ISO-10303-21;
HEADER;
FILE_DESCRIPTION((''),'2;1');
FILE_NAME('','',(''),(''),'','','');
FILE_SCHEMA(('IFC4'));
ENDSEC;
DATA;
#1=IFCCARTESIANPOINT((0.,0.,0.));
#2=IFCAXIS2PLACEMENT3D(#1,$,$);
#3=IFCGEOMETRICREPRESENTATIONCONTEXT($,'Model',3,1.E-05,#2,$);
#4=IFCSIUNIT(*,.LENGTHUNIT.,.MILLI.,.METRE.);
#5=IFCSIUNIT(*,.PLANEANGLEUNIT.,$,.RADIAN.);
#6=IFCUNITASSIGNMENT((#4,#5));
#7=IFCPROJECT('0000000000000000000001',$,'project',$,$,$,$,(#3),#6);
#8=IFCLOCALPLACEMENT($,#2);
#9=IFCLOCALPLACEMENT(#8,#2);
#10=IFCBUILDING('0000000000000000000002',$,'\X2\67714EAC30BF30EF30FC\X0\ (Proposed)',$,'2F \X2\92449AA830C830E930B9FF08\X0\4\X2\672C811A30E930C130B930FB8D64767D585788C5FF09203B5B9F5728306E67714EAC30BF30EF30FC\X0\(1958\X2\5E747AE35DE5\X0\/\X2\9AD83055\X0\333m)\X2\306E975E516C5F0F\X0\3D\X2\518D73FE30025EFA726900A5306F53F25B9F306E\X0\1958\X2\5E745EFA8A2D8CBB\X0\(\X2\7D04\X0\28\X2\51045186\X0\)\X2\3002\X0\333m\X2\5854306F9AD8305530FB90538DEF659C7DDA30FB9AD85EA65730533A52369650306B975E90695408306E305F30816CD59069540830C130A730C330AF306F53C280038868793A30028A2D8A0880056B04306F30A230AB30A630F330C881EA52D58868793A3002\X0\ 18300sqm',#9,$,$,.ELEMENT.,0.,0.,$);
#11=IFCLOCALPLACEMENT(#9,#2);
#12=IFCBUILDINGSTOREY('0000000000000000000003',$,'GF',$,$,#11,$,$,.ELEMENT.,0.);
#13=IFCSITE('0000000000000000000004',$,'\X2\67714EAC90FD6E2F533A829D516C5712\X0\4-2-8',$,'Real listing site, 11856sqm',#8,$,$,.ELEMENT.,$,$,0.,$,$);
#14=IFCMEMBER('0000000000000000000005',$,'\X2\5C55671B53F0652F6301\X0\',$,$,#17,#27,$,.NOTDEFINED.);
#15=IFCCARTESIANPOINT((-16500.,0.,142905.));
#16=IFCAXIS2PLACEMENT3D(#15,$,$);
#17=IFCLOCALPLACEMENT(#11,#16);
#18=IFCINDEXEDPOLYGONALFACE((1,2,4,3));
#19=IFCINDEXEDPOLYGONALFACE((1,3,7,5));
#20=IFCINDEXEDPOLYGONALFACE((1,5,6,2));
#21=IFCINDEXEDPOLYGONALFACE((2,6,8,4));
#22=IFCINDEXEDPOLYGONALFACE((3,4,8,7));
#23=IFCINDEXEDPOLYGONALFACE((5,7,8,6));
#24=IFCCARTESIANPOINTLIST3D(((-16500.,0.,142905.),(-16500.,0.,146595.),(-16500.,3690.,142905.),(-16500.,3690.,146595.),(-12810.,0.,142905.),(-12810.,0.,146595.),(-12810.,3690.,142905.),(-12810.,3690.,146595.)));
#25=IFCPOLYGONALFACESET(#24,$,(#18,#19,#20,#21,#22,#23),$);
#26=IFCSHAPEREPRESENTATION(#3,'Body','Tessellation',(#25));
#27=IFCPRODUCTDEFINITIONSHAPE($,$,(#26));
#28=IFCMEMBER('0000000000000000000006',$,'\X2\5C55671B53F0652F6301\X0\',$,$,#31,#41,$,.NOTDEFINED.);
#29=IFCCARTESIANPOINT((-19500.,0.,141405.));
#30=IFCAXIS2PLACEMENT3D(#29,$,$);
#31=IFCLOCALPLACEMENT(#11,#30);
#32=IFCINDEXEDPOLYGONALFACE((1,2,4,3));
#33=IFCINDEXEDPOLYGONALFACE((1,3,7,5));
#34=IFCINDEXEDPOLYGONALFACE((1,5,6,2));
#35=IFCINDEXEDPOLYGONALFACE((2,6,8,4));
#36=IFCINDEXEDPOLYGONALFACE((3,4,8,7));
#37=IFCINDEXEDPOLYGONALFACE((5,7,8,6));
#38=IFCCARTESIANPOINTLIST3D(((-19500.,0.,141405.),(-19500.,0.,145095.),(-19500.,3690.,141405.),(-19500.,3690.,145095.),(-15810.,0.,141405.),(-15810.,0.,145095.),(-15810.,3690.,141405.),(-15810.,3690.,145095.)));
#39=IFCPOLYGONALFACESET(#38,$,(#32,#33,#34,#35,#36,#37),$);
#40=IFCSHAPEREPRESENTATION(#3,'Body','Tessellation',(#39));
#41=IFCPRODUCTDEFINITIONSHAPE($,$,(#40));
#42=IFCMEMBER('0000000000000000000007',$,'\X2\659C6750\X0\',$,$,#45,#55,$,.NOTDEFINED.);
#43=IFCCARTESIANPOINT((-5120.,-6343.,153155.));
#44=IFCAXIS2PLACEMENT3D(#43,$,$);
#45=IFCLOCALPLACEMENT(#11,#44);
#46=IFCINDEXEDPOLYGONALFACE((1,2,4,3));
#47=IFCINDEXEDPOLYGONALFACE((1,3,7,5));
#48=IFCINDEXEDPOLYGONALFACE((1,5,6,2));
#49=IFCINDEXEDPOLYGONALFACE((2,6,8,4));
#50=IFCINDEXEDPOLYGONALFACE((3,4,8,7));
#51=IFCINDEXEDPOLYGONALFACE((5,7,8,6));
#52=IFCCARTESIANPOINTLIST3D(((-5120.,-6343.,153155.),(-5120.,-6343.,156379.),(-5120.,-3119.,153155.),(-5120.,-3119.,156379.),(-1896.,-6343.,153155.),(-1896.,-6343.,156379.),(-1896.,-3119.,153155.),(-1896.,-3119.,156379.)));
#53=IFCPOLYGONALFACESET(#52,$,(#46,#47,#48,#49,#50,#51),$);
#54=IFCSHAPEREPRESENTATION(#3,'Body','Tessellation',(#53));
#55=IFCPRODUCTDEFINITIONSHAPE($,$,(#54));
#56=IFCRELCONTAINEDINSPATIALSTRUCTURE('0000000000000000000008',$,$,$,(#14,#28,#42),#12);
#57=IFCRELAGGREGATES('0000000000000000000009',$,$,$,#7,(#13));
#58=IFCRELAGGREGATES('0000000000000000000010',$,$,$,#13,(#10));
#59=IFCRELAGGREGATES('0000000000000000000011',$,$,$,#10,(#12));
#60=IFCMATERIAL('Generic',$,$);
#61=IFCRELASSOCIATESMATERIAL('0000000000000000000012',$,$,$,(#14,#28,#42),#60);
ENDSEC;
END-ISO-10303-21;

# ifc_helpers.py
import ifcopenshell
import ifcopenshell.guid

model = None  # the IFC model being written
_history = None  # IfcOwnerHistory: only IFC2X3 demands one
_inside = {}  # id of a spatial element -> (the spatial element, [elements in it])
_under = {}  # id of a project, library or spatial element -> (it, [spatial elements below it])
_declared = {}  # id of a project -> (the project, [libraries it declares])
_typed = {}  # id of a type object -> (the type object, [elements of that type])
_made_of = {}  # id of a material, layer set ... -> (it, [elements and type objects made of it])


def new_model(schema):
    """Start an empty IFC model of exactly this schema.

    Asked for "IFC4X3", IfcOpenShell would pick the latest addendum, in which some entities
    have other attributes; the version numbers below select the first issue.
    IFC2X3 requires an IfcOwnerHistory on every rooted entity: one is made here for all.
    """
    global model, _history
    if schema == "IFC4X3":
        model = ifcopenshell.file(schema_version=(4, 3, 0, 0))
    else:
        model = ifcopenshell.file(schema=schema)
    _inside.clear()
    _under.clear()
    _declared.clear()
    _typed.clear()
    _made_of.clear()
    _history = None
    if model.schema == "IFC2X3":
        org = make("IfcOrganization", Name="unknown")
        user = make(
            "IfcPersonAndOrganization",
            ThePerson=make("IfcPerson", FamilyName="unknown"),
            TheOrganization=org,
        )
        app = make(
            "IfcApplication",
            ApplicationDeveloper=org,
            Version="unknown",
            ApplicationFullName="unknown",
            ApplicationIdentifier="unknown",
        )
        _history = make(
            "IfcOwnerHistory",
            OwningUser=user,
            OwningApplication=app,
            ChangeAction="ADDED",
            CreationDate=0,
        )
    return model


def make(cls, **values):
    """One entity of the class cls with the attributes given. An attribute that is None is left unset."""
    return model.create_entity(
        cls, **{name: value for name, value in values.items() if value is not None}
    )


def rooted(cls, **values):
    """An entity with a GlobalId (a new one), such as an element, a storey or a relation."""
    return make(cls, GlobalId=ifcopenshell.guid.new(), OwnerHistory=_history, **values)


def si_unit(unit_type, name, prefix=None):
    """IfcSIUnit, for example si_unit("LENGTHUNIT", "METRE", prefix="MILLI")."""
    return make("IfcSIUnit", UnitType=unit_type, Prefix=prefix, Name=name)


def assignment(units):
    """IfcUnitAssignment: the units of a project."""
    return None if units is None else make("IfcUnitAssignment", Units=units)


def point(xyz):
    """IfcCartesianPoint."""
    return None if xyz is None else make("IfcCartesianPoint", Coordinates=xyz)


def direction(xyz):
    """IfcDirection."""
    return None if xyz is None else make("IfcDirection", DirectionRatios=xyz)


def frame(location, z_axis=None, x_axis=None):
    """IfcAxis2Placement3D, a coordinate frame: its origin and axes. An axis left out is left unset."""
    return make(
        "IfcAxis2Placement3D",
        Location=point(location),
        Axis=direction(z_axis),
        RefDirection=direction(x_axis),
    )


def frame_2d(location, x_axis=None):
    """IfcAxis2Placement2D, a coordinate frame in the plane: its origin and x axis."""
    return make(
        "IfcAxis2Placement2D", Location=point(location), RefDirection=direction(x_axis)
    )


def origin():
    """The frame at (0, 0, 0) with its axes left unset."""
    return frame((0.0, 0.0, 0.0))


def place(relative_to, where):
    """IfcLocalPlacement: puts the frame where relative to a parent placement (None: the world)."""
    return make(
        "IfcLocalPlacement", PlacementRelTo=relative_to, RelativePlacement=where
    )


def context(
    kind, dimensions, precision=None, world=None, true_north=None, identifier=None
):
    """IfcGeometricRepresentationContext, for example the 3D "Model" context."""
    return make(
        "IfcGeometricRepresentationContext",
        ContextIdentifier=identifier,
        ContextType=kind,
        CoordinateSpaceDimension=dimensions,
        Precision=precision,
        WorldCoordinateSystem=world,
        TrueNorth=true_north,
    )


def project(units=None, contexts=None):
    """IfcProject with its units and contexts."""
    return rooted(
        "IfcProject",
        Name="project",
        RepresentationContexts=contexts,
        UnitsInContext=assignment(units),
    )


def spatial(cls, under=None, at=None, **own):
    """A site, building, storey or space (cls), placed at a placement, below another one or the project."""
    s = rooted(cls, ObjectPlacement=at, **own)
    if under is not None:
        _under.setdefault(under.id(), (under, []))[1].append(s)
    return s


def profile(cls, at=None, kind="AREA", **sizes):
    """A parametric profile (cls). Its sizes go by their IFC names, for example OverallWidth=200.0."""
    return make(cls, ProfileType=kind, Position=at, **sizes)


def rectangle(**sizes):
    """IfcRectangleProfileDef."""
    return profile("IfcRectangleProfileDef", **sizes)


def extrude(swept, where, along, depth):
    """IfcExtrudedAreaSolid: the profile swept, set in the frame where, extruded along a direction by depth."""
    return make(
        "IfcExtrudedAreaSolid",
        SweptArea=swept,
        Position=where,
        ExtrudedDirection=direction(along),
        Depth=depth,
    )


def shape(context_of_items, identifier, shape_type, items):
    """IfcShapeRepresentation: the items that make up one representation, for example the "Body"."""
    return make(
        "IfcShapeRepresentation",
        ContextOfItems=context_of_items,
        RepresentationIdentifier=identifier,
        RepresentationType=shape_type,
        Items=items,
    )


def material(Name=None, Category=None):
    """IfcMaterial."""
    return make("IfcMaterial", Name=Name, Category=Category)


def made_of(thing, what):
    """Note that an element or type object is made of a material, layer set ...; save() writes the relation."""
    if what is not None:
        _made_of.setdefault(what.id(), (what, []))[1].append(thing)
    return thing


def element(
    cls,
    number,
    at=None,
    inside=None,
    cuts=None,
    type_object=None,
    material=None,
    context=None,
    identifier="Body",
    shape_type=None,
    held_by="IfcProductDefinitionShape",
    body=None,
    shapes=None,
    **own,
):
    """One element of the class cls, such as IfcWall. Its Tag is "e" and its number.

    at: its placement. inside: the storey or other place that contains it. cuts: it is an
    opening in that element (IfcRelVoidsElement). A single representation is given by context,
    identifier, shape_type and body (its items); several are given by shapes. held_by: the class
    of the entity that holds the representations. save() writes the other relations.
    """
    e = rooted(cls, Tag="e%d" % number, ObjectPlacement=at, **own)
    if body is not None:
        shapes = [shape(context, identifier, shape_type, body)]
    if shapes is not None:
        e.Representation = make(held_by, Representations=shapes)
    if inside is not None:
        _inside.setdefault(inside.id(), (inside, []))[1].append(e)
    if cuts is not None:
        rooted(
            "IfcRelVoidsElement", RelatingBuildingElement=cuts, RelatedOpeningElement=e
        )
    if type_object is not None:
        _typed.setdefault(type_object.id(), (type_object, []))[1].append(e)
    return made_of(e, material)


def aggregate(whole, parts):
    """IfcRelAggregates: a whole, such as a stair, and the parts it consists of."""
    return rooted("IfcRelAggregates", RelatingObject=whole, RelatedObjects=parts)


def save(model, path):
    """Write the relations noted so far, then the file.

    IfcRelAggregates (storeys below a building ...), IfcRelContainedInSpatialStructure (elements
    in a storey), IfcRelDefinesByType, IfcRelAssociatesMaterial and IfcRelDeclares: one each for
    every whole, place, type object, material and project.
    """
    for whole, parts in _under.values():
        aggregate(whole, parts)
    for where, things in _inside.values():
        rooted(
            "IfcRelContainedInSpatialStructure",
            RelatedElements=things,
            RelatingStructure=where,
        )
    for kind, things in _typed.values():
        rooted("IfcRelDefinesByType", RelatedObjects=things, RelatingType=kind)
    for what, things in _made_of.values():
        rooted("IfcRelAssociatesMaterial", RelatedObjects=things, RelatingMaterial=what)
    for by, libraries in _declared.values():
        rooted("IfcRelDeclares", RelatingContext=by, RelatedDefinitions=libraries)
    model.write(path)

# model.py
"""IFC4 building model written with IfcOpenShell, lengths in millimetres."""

from ifc_helpers import new_model, si_unit, frame, frame_2d, origin, place, context, project, spatial, rectangle, extrude, material, element, save


model = new_model("IFC4")

# Units and contexts
model_context = context("Model", 3, precision=1e-05, world=origin())
ifc_project = project(units=[si_unit("LENGTHUNIT", "METRE", prefix="MILLI"), si_unit("PLANEANGLEUNIT", "RADIAN")], contexts=[model_context])

# Site, building, storey
site_placement = place(None, origin())
site = spatial("IfcSite", under=ifc_project, at=site_placement, Name="東京都港区芝公園4-2-8", ObjectType="Real listing site, 11856sqm", CompositionType="ELEMENT", RefElevation=0.0)
building_placement = place(site_placement, origin())
building = spatial("IfcBuilding", under=site, at=building_placement, Name="東京タワー (Proposed)", ObjectType="2F 鉄骨トラス（4本脚ラチス・赤白塗装）※実在の東京タワー(1958年竣工/高さ333m)の非公式3D再現。建物¥は史実の1958年建設費(約28億円)。333m塔は高さ・道路斜線・高度地区制限に非適合のため法適合チェックは参考表示。設計者欄はアカウント自動表示。 18300sqm", CompositionType="ELEMENT", ElevationOfRefHeight=0.0, ElevationOfTerrain=0.0)
storey_placement = place(building_placement, origin())
storey = spatial("IfcBuildingStorey", under=building, at=storey_placement, Name="GF", CompositionType="ELEMENT", Elevation=0.0)

# Shared definitions
ifc_material = material(Name="Generic")

# Members
member_1_placement = place(storey_placement, frame((-16500.0, 0.0, 142905.0)))
element("IfcMember", 1, at=member_1_placement, inside=storey, material=ifc_material, Name="展望台支持", PredefinedType="NOTDEFINED", context=model_context, shape_type="SweptSolid", body=[
    extrude(rectangle(XDim=3690.0, YDim=3690.0, at=frame_2d((1845.0, 1845.0))), frame((-16500.0, 0.0, 142905.0)), (0.0, 0.0, 1.0), 3690.0),
])
member_2_placement = place(storey_placement, frame((-19500.0, 0.0, 141405.0)))
element("IfcMember", 2, at=member_2_placement, inside=storey, material=ifc_material, Name="展望台支持", PredefinedType="NOTDEFINED", context=model_context, shape_type="SweptSolid", body=[
    extrude(rectangle(XDim=3690.0, YDim=3690.0, at=frame_2d((1845.0, 1845.0))), frame((-19500.0, 0.0, 141405.0)), (0.0, 0.0, 1.0), 3690.0),
])
member_3_placement = place(storey_placement, frame((-5120.0, -6343.0, 153155.0)))
element("IfcMember", 3, at=member_3_placement, inside=storey, material=ifc_material, Name="斜材", PredefinedType="NOTDEFINED", context=model_context, shape_type="SweptSolid", body=[
    extrude(rectangle(XDim=3224.0, YDim=3224.0, at=frame_2d((1612.0, 1612.0))), frame((-5120.0, -6343.0, 153155.0)), (0.0, 0.0, 1.0), 3224.0),
])

save(model, "model.ifc")
